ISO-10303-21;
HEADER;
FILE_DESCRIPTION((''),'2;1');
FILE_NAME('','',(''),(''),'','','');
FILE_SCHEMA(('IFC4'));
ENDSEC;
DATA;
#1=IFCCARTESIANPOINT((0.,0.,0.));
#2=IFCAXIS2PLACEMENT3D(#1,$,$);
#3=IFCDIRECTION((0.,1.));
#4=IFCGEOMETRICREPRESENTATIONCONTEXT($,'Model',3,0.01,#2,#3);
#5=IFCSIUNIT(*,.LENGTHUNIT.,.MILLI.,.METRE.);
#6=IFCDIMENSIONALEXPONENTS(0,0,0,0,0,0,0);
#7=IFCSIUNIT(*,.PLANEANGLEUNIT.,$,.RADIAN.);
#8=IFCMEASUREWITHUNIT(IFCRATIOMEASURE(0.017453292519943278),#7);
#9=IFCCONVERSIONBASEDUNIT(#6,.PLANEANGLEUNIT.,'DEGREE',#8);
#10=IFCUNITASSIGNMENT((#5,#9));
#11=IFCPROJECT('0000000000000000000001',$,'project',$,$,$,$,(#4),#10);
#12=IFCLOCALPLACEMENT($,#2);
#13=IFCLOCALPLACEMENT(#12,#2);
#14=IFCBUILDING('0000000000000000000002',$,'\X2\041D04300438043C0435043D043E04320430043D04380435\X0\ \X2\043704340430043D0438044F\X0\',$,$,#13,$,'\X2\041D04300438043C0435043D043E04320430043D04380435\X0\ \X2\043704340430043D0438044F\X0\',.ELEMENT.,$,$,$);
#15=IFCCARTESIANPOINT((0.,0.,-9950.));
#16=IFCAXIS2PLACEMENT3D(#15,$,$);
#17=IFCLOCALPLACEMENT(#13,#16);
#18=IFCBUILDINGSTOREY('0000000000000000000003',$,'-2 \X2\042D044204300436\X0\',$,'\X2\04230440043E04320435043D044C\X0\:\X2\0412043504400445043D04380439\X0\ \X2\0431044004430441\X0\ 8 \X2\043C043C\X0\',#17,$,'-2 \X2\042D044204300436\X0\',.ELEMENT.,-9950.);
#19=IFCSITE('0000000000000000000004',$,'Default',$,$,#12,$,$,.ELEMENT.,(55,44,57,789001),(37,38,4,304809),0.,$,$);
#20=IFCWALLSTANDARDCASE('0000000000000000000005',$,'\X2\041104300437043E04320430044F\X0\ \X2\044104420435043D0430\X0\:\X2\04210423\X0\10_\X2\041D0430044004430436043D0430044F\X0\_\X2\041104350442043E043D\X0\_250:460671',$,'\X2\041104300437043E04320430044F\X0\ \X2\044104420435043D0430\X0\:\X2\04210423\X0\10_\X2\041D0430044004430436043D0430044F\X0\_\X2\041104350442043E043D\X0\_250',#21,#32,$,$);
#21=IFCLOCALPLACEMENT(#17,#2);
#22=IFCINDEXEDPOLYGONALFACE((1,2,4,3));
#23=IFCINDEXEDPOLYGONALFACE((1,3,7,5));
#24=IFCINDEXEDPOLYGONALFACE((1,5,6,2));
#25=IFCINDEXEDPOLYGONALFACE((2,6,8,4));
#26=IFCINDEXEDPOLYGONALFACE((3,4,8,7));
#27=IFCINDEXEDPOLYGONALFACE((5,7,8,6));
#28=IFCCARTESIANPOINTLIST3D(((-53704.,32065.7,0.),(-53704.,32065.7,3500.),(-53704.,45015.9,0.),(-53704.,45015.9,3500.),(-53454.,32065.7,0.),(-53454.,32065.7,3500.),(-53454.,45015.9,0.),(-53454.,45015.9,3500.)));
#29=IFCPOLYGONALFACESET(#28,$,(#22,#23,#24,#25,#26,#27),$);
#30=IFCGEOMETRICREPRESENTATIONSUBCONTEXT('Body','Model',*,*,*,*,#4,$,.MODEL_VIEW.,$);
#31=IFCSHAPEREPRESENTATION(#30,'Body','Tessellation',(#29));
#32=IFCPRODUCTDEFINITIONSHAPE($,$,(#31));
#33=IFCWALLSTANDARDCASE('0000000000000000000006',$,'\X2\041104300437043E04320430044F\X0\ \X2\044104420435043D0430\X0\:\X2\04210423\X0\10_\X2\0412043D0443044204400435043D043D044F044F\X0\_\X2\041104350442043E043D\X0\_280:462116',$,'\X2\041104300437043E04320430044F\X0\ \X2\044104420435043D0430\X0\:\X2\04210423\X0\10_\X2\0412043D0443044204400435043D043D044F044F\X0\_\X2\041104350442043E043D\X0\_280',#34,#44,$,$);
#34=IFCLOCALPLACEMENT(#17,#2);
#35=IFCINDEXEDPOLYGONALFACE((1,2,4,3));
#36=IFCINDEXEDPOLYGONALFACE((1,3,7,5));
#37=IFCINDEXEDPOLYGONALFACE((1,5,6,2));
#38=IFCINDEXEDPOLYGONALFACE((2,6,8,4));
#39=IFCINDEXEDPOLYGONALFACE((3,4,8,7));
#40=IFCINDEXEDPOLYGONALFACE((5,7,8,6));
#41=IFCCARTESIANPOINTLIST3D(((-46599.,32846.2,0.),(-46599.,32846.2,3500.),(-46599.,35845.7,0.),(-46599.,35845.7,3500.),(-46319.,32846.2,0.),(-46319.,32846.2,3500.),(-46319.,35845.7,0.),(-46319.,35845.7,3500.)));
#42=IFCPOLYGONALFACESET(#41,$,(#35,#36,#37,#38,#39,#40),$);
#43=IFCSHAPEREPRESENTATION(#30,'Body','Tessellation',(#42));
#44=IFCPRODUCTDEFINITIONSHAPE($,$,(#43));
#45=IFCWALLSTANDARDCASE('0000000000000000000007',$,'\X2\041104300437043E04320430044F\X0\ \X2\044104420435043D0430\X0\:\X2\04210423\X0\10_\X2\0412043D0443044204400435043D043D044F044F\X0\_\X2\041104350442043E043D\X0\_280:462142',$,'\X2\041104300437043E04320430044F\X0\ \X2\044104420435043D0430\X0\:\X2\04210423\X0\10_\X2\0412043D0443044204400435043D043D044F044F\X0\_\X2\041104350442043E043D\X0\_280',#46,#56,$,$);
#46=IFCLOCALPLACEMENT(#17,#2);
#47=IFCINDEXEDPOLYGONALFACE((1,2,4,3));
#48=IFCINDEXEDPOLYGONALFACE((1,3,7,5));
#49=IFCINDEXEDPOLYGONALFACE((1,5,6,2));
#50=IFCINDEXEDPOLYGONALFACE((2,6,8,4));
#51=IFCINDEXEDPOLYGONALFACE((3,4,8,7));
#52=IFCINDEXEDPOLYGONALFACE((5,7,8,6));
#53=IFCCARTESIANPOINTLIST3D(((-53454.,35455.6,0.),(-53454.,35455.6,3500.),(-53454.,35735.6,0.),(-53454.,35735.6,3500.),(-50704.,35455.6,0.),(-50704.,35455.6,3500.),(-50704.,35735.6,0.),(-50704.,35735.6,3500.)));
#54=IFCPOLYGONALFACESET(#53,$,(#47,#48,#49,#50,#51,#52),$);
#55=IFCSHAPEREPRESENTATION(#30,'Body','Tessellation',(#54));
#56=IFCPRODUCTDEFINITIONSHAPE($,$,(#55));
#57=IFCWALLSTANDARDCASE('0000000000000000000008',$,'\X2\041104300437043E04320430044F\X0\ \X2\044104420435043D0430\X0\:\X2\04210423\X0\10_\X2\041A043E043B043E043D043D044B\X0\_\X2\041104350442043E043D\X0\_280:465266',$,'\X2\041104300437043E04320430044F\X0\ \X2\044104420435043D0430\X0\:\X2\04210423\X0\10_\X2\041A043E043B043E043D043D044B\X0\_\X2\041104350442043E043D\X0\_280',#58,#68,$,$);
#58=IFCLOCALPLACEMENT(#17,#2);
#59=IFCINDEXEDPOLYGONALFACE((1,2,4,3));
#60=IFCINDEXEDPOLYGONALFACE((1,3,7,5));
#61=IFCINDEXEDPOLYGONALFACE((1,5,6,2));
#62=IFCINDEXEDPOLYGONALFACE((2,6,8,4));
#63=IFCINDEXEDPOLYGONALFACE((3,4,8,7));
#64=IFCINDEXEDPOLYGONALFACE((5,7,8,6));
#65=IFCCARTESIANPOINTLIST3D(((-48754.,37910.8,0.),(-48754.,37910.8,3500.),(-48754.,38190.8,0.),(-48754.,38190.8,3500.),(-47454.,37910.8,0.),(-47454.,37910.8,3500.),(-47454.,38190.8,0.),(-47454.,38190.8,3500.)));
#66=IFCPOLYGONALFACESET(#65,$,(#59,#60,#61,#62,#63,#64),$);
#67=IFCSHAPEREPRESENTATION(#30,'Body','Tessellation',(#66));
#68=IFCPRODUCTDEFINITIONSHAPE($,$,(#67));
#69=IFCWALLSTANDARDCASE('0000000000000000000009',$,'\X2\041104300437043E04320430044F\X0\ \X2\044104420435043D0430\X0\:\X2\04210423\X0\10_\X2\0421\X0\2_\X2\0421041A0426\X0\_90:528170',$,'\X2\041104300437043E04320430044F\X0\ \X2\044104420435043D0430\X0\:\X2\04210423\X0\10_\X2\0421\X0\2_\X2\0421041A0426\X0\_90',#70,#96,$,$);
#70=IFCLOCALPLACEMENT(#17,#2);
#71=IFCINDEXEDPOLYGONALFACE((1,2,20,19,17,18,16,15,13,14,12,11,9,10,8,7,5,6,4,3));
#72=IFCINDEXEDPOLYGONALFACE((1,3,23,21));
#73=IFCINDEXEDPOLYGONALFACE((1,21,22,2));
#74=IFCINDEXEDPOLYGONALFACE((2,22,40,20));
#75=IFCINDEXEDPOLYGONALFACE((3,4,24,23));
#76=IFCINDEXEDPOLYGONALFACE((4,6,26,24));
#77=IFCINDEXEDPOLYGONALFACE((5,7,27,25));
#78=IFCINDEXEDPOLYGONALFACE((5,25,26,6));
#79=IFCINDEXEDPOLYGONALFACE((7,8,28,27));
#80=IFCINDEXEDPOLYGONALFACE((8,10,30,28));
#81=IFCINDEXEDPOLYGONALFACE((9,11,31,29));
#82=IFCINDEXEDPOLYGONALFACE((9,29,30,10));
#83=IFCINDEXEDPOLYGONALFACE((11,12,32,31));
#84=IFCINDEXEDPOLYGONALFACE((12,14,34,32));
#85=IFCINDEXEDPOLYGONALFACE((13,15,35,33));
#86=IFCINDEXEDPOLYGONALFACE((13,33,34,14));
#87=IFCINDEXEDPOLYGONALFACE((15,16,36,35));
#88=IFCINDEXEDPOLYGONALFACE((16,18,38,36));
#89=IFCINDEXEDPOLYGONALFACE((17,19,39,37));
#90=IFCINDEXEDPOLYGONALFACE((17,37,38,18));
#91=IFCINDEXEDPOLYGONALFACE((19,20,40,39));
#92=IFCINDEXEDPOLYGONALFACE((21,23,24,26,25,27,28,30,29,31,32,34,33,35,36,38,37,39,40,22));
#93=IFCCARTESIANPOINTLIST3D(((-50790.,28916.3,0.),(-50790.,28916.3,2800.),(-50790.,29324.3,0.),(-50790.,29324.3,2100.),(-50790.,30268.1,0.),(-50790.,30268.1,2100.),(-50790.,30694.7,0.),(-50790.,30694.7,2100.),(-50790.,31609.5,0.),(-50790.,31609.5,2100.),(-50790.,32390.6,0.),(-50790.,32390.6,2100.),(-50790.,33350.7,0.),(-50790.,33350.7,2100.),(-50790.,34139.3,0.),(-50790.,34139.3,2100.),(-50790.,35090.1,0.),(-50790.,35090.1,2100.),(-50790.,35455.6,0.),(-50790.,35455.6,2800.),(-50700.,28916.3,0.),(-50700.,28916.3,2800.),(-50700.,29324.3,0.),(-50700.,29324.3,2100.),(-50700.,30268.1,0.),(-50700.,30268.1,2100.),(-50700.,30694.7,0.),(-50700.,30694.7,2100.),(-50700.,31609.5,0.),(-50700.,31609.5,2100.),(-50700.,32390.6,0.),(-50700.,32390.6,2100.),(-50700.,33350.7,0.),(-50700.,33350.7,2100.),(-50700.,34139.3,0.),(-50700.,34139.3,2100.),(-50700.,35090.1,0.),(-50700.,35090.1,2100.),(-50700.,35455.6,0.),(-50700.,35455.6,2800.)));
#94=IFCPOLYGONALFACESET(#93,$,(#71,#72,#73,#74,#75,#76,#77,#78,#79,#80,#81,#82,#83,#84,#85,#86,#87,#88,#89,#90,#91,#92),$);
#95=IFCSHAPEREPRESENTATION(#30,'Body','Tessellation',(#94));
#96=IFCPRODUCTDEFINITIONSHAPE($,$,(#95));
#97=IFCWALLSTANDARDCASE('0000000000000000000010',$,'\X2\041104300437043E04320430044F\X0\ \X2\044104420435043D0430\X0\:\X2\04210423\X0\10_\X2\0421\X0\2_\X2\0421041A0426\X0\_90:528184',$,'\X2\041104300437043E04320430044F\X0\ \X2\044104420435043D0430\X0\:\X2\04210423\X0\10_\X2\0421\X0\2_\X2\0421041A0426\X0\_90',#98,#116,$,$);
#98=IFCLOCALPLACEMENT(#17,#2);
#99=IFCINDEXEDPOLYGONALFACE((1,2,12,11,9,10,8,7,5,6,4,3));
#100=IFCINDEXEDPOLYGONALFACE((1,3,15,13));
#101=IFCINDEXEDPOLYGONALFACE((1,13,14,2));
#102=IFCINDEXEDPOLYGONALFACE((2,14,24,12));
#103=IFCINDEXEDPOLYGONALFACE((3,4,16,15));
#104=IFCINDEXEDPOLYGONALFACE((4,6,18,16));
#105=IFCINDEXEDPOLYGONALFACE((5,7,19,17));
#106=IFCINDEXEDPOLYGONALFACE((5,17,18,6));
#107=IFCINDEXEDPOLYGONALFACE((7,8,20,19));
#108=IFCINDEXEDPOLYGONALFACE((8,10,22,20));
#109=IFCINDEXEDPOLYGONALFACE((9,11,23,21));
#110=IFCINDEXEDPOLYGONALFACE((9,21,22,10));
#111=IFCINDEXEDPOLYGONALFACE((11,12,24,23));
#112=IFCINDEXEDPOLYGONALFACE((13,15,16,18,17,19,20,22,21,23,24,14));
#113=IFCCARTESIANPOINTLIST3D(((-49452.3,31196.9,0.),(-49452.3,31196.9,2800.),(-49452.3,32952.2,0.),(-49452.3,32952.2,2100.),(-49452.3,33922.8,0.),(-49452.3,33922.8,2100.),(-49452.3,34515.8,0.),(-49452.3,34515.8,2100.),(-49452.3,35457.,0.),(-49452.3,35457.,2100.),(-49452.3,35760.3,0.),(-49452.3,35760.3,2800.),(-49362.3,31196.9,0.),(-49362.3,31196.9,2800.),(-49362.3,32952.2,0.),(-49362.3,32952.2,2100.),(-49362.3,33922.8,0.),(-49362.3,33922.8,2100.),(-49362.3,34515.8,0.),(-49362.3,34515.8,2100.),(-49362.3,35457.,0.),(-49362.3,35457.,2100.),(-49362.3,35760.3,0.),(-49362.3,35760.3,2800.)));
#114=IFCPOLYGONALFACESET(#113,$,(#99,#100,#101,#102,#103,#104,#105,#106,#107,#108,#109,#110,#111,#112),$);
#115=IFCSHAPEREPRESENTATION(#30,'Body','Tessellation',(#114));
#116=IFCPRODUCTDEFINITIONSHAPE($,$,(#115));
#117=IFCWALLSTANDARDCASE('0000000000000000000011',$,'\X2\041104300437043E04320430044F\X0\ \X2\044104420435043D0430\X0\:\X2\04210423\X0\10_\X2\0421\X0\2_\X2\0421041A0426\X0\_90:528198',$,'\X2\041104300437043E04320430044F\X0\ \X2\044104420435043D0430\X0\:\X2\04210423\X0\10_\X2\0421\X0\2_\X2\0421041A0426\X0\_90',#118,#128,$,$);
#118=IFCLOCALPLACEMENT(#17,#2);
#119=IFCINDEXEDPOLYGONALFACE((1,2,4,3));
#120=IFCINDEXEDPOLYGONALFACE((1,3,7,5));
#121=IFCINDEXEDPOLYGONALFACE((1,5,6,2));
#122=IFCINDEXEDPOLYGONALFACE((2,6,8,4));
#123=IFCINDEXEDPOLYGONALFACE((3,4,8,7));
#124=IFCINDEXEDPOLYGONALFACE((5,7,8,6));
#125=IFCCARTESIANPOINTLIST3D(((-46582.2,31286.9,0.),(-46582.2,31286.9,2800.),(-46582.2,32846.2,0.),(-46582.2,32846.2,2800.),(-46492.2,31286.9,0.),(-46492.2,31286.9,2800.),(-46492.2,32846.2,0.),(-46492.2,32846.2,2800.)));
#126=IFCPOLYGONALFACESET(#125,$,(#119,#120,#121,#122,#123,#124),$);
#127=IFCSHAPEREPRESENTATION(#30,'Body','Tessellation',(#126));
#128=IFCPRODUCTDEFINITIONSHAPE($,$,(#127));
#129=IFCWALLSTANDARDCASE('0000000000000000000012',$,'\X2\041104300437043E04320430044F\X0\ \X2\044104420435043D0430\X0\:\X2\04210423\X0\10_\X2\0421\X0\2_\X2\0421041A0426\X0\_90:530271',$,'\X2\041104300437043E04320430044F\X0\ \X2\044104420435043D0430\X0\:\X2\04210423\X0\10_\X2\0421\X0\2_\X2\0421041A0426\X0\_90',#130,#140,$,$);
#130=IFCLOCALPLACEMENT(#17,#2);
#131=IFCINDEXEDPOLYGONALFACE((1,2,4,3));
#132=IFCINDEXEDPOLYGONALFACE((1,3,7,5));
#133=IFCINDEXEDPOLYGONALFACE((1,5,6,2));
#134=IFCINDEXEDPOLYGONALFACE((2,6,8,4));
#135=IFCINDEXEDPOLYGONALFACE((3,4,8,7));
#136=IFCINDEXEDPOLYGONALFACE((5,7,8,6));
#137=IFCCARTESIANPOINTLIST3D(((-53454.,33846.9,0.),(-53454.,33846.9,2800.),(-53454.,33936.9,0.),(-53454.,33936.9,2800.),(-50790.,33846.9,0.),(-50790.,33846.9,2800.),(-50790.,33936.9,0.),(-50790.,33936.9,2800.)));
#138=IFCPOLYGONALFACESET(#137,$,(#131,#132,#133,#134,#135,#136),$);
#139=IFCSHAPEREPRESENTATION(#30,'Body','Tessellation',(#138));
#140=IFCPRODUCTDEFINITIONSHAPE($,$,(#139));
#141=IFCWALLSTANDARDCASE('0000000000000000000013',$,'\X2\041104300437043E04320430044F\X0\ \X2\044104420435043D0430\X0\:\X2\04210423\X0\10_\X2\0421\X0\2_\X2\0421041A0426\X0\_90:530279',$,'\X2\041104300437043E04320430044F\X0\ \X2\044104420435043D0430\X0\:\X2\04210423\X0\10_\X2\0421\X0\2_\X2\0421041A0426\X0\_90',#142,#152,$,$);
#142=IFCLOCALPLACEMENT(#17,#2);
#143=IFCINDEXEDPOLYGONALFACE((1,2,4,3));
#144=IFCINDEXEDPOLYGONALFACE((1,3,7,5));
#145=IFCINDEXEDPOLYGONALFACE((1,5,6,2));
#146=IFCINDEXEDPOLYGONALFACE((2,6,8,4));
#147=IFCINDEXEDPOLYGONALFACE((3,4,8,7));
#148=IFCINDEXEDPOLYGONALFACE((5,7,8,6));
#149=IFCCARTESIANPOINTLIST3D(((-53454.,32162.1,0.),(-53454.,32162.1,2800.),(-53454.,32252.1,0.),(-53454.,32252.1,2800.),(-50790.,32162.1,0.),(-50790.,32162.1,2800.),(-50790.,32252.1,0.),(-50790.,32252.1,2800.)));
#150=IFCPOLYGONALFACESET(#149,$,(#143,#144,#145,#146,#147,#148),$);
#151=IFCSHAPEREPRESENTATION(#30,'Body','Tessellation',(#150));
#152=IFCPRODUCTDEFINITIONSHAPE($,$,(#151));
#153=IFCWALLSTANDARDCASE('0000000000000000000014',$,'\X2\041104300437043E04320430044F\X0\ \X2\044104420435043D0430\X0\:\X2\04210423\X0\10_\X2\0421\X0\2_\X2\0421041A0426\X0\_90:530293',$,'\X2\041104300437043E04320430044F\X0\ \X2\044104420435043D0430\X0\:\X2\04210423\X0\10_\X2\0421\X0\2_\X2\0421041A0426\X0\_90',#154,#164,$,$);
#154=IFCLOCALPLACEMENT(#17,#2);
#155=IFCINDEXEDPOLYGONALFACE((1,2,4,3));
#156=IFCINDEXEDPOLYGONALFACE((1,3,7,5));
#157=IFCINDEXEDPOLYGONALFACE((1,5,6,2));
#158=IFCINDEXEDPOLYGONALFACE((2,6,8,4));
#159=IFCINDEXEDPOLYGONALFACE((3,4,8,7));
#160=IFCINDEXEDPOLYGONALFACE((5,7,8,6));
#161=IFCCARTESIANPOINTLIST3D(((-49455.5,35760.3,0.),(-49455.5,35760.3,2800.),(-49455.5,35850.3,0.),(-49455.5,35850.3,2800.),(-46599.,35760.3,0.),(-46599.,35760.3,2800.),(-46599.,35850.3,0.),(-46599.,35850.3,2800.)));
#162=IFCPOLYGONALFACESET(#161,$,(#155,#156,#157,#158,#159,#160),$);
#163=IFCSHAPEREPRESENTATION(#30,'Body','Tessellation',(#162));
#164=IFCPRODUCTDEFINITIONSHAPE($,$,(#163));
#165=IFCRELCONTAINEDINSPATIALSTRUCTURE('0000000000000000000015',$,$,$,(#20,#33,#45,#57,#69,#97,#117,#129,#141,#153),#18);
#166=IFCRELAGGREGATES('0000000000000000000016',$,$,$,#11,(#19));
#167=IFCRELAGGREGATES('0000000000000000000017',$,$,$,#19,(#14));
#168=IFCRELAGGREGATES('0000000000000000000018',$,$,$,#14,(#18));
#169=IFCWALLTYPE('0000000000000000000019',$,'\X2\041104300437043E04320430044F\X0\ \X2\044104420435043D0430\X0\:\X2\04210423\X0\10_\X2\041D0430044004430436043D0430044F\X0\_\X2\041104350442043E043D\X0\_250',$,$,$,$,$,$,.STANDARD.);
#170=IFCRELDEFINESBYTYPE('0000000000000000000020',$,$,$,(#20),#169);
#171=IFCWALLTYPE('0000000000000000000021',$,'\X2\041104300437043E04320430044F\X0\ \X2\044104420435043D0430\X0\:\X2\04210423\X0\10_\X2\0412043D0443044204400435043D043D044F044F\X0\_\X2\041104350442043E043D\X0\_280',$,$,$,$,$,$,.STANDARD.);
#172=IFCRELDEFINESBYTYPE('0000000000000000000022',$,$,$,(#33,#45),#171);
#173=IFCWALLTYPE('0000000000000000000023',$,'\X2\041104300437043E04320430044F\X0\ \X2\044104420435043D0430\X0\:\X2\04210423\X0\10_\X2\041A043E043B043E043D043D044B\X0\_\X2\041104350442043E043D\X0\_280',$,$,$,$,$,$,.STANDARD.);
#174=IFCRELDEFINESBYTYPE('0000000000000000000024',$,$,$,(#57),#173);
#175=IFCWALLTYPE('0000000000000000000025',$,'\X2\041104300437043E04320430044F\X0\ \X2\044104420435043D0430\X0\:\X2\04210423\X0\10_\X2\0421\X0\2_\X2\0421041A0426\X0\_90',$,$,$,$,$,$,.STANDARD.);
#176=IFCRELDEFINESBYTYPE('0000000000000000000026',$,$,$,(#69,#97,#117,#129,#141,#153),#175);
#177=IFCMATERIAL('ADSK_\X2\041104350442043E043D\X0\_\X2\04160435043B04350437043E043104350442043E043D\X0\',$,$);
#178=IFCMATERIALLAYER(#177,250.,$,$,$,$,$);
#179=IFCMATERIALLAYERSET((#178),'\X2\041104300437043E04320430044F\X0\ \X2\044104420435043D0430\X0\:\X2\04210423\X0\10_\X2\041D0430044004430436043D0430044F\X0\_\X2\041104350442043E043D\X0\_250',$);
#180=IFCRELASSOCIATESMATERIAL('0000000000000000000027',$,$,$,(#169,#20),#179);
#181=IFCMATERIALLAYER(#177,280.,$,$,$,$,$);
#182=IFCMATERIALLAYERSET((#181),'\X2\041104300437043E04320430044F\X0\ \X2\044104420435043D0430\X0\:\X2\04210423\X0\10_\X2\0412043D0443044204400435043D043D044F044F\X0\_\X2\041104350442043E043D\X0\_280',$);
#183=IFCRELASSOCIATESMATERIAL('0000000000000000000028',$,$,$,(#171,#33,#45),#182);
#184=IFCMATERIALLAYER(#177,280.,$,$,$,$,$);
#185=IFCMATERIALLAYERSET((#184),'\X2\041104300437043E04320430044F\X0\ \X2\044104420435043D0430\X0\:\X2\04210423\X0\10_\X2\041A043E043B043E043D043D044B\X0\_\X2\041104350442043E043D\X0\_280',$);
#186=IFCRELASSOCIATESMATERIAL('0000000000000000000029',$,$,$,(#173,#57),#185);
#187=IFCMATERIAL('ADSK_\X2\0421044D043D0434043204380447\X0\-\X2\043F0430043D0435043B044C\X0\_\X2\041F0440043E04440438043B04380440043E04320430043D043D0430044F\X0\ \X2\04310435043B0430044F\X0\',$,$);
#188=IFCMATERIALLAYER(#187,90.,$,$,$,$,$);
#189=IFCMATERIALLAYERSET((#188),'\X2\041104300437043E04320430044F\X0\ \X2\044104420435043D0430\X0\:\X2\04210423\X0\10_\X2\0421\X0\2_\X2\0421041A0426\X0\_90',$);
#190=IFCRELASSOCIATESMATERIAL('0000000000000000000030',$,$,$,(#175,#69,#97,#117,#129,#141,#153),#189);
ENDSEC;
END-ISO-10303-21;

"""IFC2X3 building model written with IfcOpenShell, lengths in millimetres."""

from ifc_helpers import new_model, entity, si_unit, converted_unit, direction, frame, frame_2d, origin, place, context, subcontext, project, spatial, rectangle, extrude, material, layer, layer_set, layer_usage, type_object, element, save


model = new_model("IFC2X3")

# Units and contexts
model_context = context("Model", 3, precision=0.01, world=origin(), true_north=direction((0.0, 1.0)))
body_context = subcontext(model_context, "Body", "Model", "MODEL_VIEW")
ifc_project = project(units=[si_unit("LENGTHUNIT", "METRE", prefix="MILLI"), converted_unit("PLANEANGLEUNIT", "DEGREE", entity("IfcRatioMeasure", 0.017453292519943278), si_unit("PLANEANGLEUNIT", "RADIAN"), dimensions=[0, 0, 0, 0, 0, 0, 0])], contexts=[model_context])

# Site, building, storey
site_placement = place(None, origin())
site = spatial("IfcSite", under=ifc_project, at=site_placement, Name="Default", CompositionType="ELEMENT", RefLatitude=(55, 44, 57, 789001), RefLongitude=(37, 38, 4, 304809), RefElevation=0.0)
building_placement = place(site_placement, origin())
building = spatial("IfcBuilding", under=site, at=building_placement, Name="Наименование здания", LongName="Наименование здания", CompositionType="ELEMENT")
storey_placement = place(building_placement, frame((0.0, 0.0, -9950.0)))
storey = spatial("IfcBuildingStorey", under=building, at=storey_placement, Name="-2 Этаж", ObjectType="Уровень:Верхний брус 8 мм", LongName="-2 Этаж", CompositionType="ELEMENT", Elevation=-9950.0)

# Walls
ifc_material_1 = material(Name="ADSK_Бетон_Железобетон")
ifc_layer_1 = layer(ifc_material_1, 250.0)
ifc_layer_set_1 = layer_set([ifc_layer_1], Name="Базовая стена:СУ10_Наружная_Бетон_250")
ifc_layer_usage_1 = layer_usage(ifc_layer_set_1, "AXIS2", "NEGATIVE", 125.0)
wall_type_1 = type_object("IfcWallType", Name="Базовая стена:СУ10_Наружная_Бетон_250", PredefinedType="STANDARD", material=ifc_layer_set_1)
wall_1_placement = place(storey_placement, frame((-53579.0, 32065.7, 0.0), z_axis=(0.0, 0.0, 1.0), x_axis=(0.0, 1.0, 0.0)))
element("IfcWallStandardCase", 1, at=wall_1_placement, inside=storey, type_object=wall_type_1, material=ifc_layer_usage_1, Name="Базовая стена:СУ10_Наружная_Бетон_250:460671", ObjectType="Базовая стена:СУ10_Наружная_Бетон_250", context=body_context, shape_type="SweptSolid", body=[
    extrude(rectangle(XDim=12950.3, YDim=250.0, at=frame_2d((6475.1, 0.0), x_axis=(-1.0, 0.0))), origin(), (0.0, 0.0, 1.0), 3500.0),
])
ifc_layer_2 = layer(ifc_material_1, 280.0)
ifc_layer_set_2 = layer_set([ifc_layer_2], Name="Базовая стена:СУ10_Внутренняя_Бетон_280")
ifc_layer_usage_2 = layer_usage(ifc_layer_set_2, "AXIS2", "NEGATIVE", 140.0)
wall_type_2 = type_object("IfcWallType", Name="Базовая стена:СУ10_Внутренняя_Бетон_280", PredefinedType="STANDARD", material=ifc_layer_set_2)
wall_2_placement = place(storey_placement, frame((-46459.0, 35845.7, 0.0), z_axis=(0.0, 0.0, 1.0), x_axis=(0.0, -1.0, 0.0)))
element("IfcWallStandardCase", 2, at=wall_2_placement, inside=storey, type_object=wall_type_2, material=ifc_layer_usage_2, Name="Базовая стена:СУ10_Внутренняя_Бетон_280:462116", ObjectType="Базовая стена:СУ10_Внутренняя_Бетон_280", context=body_context, shape_type="SweptSolid", body=[
    extrude(rectangle(XDim=2999.5, YDim=280.0, at=frame_2d((1499.7, 0.0), x_axis=(-1.0, 0.0))), origin(), (0.0, 0.0, 1.0), 3500.0),
])
wall_3_placement = place(storey_placement, frame((-50704.0, 35595.6, 0.0), z_axis=(0.0, 0.0, 1.0), x_axis=(-1.0, 0.0, 0.0)))
element("IfcWallStandardCase", 3, at=wall_3_placement, inside=storey, type_object=wall_type_2, material=ifc_layer_usage_2, Name="Базовая стена:СУ10_Внутренняя_Бетон_280:462142", ObjectType="Базовая стена:СУ10_Внутренняя_Бетон_280", context=body_context, shape_type="SweptSolid", body=[
    extrude(rectangle(XDim=2750.0, YDim=280.0, at=frame_2d((1375.0, 0.0), x_axis=(-1.0, 0.0))), origin(), (0.0, 0.0, 1.0), 3500.0),
])
ifc_layer_3 = layer(ifc_material_1, 280.0)
ifc_layer_set_3 = layer_set([ifc_layer_3], Name="Базовая стена:СУ10_Колонны_Бетон_280")
ifc_layer_usage_3 = layer_usage(ifc_layer_set_3, "AXIS2", "NEGATIVE", 140.0)
wall_type_3 = type_object("IfcWallType", Name="Базовая стена:СУ10_Колонны_Бетон_280", PredefinedType="STANDARD", material=ifc_layer_set_3)
wall_4_placement = place(storey_placement, frame((-47454.0, 38050.8, 0.0), z_axis=(0.0, 0.0, 1.0), x_axis=(-1.0, 0.0, 0.0)))
element("IfcWallStandardCase", 4, at=wall_4_placement, inside=storey, type_object=wall_type_3, material=ifc_layer_usage_3, Name="Базовая стена:СУ10_Колонны_Бетон_280:465266", ObjectType="Базовая стена:СУ10_Колонны_Бетон_280", context=body_context, shape_type="SweptSolid", body=[
    extrude(rectangle(XDim=1300.0, YDim=280.0, at=frame_2d((650.0, 0.0), x_axis=(-1.0, 0.0))), origin(), (0.0, 0.0, 1.0), 3500.0),
])

# Walls, openings
ifc_material_2 = material(Name="ADSK_Сэндвич-панель_Профилированная белая")
ifc_layer_4 = layer(ifc_material_2, 90.0)
ifc_layer_set_4 = layer_set([ifc_layer_4], Name="Базовая стена:СУ10_С2_СКЦ_90")
ifc_layer_usage_4 = layer_usage(ifc_layer_set_4, "AXIS2", "NEGATIVE", 45.0)
wall_type_4 = type_object("IfcWallType", Name="Базовая стена:СУ10_С2_СКЦ_90", PredefinedType="STANDARD", material=ifc_layer_set_4)
wall_5_placement = place(storey_placement, frame((-50745.0, 35455.6, 0.0), z_axis=(0.0, 0.0, 1.0), x_axis=(0.0, -1.0, 0.0)))
wall_5 = element("IfcWallStandardCase", 5, at=wall_5_placement, inside=storey, type_object=wall_type_4, material=ifc_layer_usage_4, Name="Базовая стена:СУ10_С2_СКЦ_90:528170", ObjectType="Базовая стена:СУ10_С2_СКЦ_90", context=body_context, shape_type="SweptSolid", body=[
    extrude(rectangle(XDim=6539.3, YDim=90.0, at=frame_2d((3269.6, 0.0), x_axis=(-1.0, 0.0))), origin(), (0.0, 0.0, 1.0), 2800.0),
])
opening_1_placement = place(wall_5_placement, origin())
element("IfcOpeningElement", 6, at=opening_1_placement, cuts=wall_5, ObjectType="Opening", context=body_context, shape_type="SweptSolid", body=[
    extrude(rectangle(XDim=2100.0, YDim=950.7, at=frame_2d((0.0, 0.0), x_axis=(1.0, 0.0))), frame((840.9, -45.0, 1050.0), z_axis=(0.0, 1.0, 0.0), x_axis=(0.0, 0.0, -1.0)), (0.0, 0.0, 1.0), 90.0),
])
opening_2_placement = place(wall_5_placement, origin())
element("IfcOpeningElement", 7, at=opening_2_placement, cuts=wall_5, ObjectType="Opening", context=body_context, shape_type="SweptSolid", body=[
    extrude(rectangle(XDim=2100.0, YDim=960.1, at=frame_2d((0.0, 0.0), x_axis=(1.0, 0.0))), frame((2585.0, -45.0, 1050.0), z_axis=(0.0, 1.0, 0.0), x_axis=(0.0, 0.0, -1.0)), (0.0, 0.0, 1.0), 90.0),
])
opening_3_placement = place(wall_5_placement, origin())
element("IfcOpeningElement", 8, at=opening_3_placement, cuts=wall_5, ObjectType="Opening", context=body_context, shape_type="SweptSolid", body=[
    extrude(rectangle(XDim=2100.0, YDim=914.9, at=frame_2d((0.0, 0.0), x_axis=(1.0, 0.0))), frame((4303.5, -45.0, 1050.0), z_axis=(0.0, 1.0, 0.0), x_axis=(0.0, 0.0, -1.0)), (0.0, 0.0, 1.0), 90.0),
])
opening_4_placement = place(wall_5_placement, origin())
element("IfcOpeningElement", 9, at=opening_4_placement, cuts=wall_5, ObjectType="Opening", context=body_context, shape_type="SweptSolid", body=[
    extrude(rectangle(XDim=2100.0, YDim=943.8, at=frame_2d((0.0, 0.0), x_axis=(1.0, 0.0))), frame((5659.4, -45.0, 1050.0), z_axis=(0.0, 1.0, 0.0), x_axis=(0.0, 0.0, -1.0)), (0.0, 0.0, 1.0), 90.0),
])
wall_6_placement = place(storey_placement, frame((-49407.3, 35760.3, 0.0), z_axis=(0.0, 0.0, 1.0), x_axis=(0.0, -1.0, 0.0)))
wall_6 = element("IfcWallStandardCase", 10, at=wall_6_placement, inside=storey, type_object=wall_type_4, material=ifc_layer_usage_4, Name="Базовая стена:СУ10_С2_СКЦ_90:528184", ObjectType="Базовая стена:СУ10_С2_СКЦ_90", context=body_context, shape_type="SweptSolid", body=[
    extrude(rectangle(XDim=4563.4, YDim=90.0, at=frame_2d((2281.7, 0.0), x_axis=(-1.0, 0.0))), origin(), (0.0, 0.0, 1.0), 2800.0),
])
opening_5_placement = place(wall_6_placement, origin())
element("IfcOpeningElement", 11, at=opening_5_placement, cuts=wall_6, ObjectType="Opening", context=body_context, shape_type="SweptSolid", body=[
    extrude(rectangle(XDim=2100.0, YDim=941.2, at=frame_2d((0.0, 0.0), x_axis=(1.0, 0.0))), frame((773.9, -45.0, 1050.0), z_axis=(0.0, 1.0, 0.0), x_axis=(0.0, 0.0, -1.0)), (0.0, 0.0, 1.0), 90.0),
])
opening_6_placement = place(wall_6_placement, origin())
element("IfcOpeningElement", 12, at=opening_6_placement, cuts=wall_6, ObjectType="Opening", context=body_context, shape_type="SweptSolid", body=[
    extrude(rectangle(XDim=2100.0, YDim=970.6, at=frame_2d((0.0, 0.0), x_axis=(1.0, 0.0))), frame((2322.9, -45.0, 1050.0), z_axis=(0.0, 1.0, 0.0), x_axis=(0.0, 0.0, -1.0)), (0.0, 0.0, 1.0), 90.0),
])

# Walls
wall_7_placement = place(storey_placement, frame((-46537.2, 32846.2, 0.0), z_axis=(0.0, 0.0, 1.0), x_axis=(0.0, -1.0, 0.0)))
element("IfcWallStandardCase", 13, at=wall_7_placement, inside=storey, type_object=wall_type_4, material=ifc_layer_usage_4, Name="Базовая стена:СУ10_С2_СКЦ_90:528198", ObjectType="Базовая стена:СУ10_С2_СКЦ_90", context=body_context, shape_type="SweptSolid", body=[
    extrude(rectangle(XDim=1559.3, YDim=90.0, at=frame_2d((779.6, 0.0), x_axis=(-1.0, 0.0))), origin(), (0.0, 0.0, 1.0), 2800.0),
])
for number, where, z_axis, x_axis, name in (
    (14, (-50790.0, 33891.9, 0.0), (0.0, 0.0, 1.0), (-1.0, 0.0, 0.0), "Базовая стена:СУ10_С2_СКЦ_90:530271"),
    (15, (-50790.0, 32207.1, 0.0), (0.0, 0.0, 1.0), (-1.0, 0.0, 0.0), "Базовая стена:СУ10_С2_СКЦ_90:530279"),
):
    element("IfcWallStandardCase", number, at=place(storey_placement, frame(where, z_axis=z_axis, x_axis=x_axis)), inside=storey, type_object=wall_type_4, material=ifc_layer_usage_4, Name=name, ObjectType="Базовая стена:СУ10_С2_СКЦ_90", context=body_context, shape_type="SweptSolid", body=[
        extrude(rectangle(XDim=2664.0, YDim=90.0, at=frame_2d((1332.0, 0.0), x_axis=(-1.0, 0.0))), origin(), (0.0, 0.0, 1.0), 2800.0),
    ])
wall_8_placement = place(storey_placement, frame((-46599.0, 35805.3, 0.0), z_axis=(0.0, 0.0, 1.0), x_axis=(-1.0, 0.0, 0.0)))
element("IfcWallStandardCase", 16, at=wall_8_placement, inside=storey, type_object=wall_type_4, material=ifc_layer_usage_4, Name="Базовая стена:СУ10_С2_СКЦ_90:530293", ObjectType="Базовая стена:СУ10_С2_СКЦ_90", context=body_context, shape_type="SweptSolid", body=[
    extrude(rectangle(XDim=2856.5, YDim=90.0, at=frame_2d((1428.3, 0.0), x_axis=(-1.0, 0.0))), origin(), (0.0, 0.0, 1.0), 2800.0),
])

save(model, "model.ifc")
